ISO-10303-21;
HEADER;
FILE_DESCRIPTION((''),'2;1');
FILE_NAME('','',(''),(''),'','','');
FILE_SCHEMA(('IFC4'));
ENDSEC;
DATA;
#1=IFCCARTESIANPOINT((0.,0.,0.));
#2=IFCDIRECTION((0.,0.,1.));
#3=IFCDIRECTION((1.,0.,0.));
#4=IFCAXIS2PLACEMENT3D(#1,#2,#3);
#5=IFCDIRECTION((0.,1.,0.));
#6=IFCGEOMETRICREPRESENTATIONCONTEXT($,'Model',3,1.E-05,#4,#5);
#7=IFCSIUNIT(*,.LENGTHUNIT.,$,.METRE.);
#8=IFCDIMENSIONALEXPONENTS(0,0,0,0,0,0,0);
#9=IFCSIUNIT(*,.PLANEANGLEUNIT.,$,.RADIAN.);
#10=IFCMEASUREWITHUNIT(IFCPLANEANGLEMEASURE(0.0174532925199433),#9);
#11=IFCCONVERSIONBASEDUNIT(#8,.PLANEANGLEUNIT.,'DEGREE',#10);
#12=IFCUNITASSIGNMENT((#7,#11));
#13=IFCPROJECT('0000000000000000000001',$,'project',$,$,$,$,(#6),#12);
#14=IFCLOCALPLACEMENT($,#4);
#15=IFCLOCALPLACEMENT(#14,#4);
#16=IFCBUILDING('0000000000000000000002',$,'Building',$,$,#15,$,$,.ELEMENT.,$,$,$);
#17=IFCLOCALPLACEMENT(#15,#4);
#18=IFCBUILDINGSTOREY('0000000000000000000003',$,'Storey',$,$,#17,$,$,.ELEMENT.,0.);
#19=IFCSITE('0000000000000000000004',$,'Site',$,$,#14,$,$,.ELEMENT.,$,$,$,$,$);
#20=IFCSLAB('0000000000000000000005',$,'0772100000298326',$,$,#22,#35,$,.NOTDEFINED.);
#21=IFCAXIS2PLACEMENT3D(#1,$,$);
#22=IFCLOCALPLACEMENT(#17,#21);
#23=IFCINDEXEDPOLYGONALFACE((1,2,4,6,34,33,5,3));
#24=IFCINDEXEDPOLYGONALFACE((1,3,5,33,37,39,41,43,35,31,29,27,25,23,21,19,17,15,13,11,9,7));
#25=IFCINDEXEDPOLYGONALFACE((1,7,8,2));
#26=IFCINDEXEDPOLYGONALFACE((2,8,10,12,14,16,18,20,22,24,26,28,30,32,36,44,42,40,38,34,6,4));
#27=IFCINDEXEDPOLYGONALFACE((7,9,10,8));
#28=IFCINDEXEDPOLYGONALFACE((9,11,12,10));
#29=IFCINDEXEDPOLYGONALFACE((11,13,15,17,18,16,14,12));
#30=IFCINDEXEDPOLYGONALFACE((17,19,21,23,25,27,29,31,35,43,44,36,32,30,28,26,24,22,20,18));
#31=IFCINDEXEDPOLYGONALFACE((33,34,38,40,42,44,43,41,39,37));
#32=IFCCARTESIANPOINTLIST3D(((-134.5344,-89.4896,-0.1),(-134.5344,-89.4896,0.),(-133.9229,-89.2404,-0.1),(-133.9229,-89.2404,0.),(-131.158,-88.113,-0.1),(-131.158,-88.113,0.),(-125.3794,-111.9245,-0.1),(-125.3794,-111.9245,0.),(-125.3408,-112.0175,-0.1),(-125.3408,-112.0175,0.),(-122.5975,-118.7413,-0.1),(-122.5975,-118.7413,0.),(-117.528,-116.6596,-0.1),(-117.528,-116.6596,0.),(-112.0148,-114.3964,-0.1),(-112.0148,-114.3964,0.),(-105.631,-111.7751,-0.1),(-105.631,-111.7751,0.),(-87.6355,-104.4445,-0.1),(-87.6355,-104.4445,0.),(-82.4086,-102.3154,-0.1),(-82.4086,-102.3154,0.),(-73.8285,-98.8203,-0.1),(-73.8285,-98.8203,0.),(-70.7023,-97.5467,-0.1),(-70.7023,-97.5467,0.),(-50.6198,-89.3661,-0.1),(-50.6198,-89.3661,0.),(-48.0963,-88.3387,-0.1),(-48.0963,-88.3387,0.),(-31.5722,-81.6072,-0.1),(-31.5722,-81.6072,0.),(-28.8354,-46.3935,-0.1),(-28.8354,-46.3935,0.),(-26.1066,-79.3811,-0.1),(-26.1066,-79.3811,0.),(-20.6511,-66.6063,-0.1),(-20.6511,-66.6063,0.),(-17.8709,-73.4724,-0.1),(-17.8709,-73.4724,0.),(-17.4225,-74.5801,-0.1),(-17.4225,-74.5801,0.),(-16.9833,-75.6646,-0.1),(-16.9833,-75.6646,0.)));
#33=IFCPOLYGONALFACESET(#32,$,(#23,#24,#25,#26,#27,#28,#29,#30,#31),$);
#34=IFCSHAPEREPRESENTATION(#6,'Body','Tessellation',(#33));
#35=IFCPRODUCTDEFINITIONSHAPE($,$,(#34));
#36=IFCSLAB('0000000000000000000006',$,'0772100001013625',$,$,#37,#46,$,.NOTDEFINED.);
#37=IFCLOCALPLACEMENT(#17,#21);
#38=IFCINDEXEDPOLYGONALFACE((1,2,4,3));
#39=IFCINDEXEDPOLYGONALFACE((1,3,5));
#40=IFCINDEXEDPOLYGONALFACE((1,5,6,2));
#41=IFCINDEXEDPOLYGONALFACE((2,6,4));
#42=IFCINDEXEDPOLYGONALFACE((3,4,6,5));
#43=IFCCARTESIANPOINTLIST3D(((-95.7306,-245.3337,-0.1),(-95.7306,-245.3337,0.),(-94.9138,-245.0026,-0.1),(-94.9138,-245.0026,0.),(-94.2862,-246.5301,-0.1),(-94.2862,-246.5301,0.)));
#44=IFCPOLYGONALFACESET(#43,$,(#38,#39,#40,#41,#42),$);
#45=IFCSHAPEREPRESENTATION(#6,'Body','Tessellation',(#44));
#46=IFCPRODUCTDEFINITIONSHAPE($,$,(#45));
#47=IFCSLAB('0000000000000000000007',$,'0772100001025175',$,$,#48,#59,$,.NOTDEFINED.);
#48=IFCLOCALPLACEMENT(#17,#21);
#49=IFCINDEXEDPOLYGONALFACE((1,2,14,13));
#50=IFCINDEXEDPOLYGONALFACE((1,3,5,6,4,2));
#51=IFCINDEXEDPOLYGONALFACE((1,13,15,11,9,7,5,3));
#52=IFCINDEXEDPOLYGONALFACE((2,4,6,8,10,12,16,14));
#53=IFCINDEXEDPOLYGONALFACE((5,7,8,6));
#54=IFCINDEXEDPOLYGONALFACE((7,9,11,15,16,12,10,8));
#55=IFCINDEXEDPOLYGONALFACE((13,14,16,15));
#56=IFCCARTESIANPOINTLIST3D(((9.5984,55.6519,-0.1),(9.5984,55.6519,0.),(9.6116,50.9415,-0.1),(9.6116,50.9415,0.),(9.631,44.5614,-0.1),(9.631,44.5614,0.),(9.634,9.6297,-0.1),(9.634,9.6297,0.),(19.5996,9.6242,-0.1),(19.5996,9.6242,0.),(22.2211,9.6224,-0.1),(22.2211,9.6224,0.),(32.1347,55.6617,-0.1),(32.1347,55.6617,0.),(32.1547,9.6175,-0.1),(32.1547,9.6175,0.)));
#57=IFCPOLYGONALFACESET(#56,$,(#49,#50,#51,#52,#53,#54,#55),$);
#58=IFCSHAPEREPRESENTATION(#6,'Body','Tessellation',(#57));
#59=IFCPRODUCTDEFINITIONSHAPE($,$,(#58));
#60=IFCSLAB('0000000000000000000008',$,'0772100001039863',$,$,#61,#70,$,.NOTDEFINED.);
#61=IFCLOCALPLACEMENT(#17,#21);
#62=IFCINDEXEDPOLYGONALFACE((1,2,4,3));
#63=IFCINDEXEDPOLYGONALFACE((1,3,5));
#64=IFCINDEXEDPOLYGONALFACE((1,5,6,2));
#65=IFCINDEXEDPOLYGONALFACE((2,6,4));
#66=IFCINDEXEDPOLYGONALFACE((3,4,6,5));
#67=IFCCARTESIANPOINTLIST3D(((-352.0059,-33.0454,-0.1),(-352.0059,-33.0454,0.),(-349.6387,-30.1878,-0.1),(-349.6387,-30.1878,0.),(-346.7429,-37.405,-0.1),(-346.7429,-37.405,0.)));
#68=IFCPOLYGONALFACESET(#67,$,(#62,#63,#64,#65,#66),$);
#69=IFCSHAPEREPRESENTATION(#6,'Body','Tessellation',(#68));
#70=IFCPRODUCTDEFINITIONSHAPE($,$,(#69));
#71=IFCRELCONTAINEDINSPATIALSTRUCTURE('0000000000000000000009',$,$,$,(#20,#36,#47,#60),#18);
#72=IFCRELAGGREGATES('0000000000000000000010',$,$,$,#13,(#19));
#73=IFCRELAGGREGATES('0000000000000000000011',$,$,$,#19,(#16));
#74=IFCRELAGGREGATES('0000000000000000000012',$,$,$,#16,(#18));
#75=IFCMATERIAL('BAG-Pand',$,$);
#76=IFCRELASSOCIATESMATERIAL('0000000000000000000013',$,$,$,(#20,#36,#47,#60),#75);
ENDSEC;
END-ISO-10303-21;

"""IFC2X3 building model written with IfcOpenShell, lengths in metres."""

from ifc_helpers import new_model, entity, si_unit, converted_unit, direction, frame, origin_with_axes, place, context, project, spatial, polyline, outline, extrude, material, element, save


model = new_model("IFC2X3")

# Units and contexts
model_context = context("Model", 3, precision=1e-05, world=origin_with_axes(), true_north=direction((0.0, 1.0, 0.0)))
ifc_project = project(units=[si_unit("LENGTHUNIT", "METRE"), converted_unit("PLANEANGLEUNIT", "DEGREE", entity("IfcPlaneAngleMeasure", 0.0174532925199433), si_unit("PLANEANGLEUNIT", "RADIAN"), dimensions=[0, 0, 0, 0, 0, 0, 0])], contexts=[model_context])

# Site, building, storey
site_placement = place(None, origin_with_axes())
site = spatial("IfcSite", under=ifc_project, at=site_placement, Name="Site", CompositionType="ELEMENT")
building_placement = place(site_placement, origin_with_axes())
building = spatial("IfcBuilding", under=site, at=building_placement, Name="Building", CompositionType="ELEMENT")
storey_placement = place(building_placement, origin_with_axes())
storey = spatial("IfcBuildingStorey", under=building, at=storey_placement, Name="Storey", CompositionType="ELEMENT", Elevation=0.0)

# Slabs
ifc_material = material(Name="BAG-Pand")
slab_1_placement = place(storey_placement, frame((0.0, 0.0, -0.1), z_axis=(0.0, 0.0, 1.0), x_axis=(1.0, 0.0, 0.0)))
element("IfcSlab", 1, at=slab_1_placement, inside=storey, material=ifc_material, Name="0772100000298326", PredefinedType="NOTDEFINED", context=model_context, shape_type="SweptSolid", body=[
    extrude(outline(polyline([(-125.3408, -112.0175), (-125.3794, -111.9245), (-134.5344, -89.4896), (-133.9229, -89.2404), (-131.158, -88.113), (-28.8354, -46.3935), (-20.6511, -66.6063), (-17.8709, -73.4724), (-17.4225, -74.5801), (-16.9833, -75.6646), (-26.1066, -79.3811), (-31.5722, -81.6072), (-48.0963, -88.3387), (-50.6198, -89.3661), (-70.7023, -97.5467), (-73.8285, -98.8203), (-82.4086, -102.3154), (-87.6355, -104.4445), (-105.631, -111.7751), (-112.0148, -114.3964), (-117.528, -116.6596), (-122.5975, -118.7413), (-125.3408, -112.0175)])), origin_with_axes(), (0.0, 0.0, 1.0), 0.1),
])
slab_2_placement = place(storey_placement, frame((0.0, 0.0, -0.1), z_axis=(0.0, 0.0, 1.0), x_axis=(1.0, 0.0, 0.0)))
element("IfcSlab", 2, at=slab_2_placement, inside=storey, material=ifc_material, Name="0772100001013625", PredefinedType="NOTDEFINED", context=model_context, shape_type="SweptSolid", body=[
    extrude(outline(polyline([(-94.9138, -245.0026), (-94.2862, -246.5301), (-95.7306, -245.3337), (-94.9138, -245.0026)])), origin_with_axes(), (0.0, 0.0, 1.0), 0.1),
])
slab_3_placement = place(storey_placement, frame((0.0, 0.0, -0.1), z_axis=(0.0, 0.0, 1.0), x_axis=(1.0, 0.0, 0.0)))
element("IfcSlab", 3, at=slab_3_placement, inside=storey, material=ifc_material, Name="0772100001025175", PredefinedType="NOTDEFINED", context=model_context, shape_type="SweptSolid", body=[
    extrude(outline(polyline([(9.631, 44.5614), (9.6116, 50.9415), (9.5984, 55.6519), (32.1347, 55.6617), (32.1547, 9.6175), (22.2211, 9.6224), (19.5996, 9.6242), (9.634, 9.6297), (9.631, 44.5614)])), origin_with_axes(), (0.0, 0.0, 1.0), 0.1),
])
slab_4_placement = place(storey_placement, frame((0.0, 0.0, -0.1), z_axis=(0.0, 0.0, 1.0), x_axis=(1.0, 0.0, 0.0)))
element("IfcSlab", 4, at=slab_4_placement, inside=storey, material=ifc_material, Name="0772100001039863", PredefinedType="NOTDEFINED", context=model_context, shape_type="SweptSolid", body=[
    extrude(outline(polyline([(-346.7429, -37.405), (-352.0059, -33.0454), (-349.6387, -30.1878), (-346.7429, -37.405)])), origin_with_axes(), (0.0, 0.0, 1.0), 0.1),
])

save(model, "model.ifc")
